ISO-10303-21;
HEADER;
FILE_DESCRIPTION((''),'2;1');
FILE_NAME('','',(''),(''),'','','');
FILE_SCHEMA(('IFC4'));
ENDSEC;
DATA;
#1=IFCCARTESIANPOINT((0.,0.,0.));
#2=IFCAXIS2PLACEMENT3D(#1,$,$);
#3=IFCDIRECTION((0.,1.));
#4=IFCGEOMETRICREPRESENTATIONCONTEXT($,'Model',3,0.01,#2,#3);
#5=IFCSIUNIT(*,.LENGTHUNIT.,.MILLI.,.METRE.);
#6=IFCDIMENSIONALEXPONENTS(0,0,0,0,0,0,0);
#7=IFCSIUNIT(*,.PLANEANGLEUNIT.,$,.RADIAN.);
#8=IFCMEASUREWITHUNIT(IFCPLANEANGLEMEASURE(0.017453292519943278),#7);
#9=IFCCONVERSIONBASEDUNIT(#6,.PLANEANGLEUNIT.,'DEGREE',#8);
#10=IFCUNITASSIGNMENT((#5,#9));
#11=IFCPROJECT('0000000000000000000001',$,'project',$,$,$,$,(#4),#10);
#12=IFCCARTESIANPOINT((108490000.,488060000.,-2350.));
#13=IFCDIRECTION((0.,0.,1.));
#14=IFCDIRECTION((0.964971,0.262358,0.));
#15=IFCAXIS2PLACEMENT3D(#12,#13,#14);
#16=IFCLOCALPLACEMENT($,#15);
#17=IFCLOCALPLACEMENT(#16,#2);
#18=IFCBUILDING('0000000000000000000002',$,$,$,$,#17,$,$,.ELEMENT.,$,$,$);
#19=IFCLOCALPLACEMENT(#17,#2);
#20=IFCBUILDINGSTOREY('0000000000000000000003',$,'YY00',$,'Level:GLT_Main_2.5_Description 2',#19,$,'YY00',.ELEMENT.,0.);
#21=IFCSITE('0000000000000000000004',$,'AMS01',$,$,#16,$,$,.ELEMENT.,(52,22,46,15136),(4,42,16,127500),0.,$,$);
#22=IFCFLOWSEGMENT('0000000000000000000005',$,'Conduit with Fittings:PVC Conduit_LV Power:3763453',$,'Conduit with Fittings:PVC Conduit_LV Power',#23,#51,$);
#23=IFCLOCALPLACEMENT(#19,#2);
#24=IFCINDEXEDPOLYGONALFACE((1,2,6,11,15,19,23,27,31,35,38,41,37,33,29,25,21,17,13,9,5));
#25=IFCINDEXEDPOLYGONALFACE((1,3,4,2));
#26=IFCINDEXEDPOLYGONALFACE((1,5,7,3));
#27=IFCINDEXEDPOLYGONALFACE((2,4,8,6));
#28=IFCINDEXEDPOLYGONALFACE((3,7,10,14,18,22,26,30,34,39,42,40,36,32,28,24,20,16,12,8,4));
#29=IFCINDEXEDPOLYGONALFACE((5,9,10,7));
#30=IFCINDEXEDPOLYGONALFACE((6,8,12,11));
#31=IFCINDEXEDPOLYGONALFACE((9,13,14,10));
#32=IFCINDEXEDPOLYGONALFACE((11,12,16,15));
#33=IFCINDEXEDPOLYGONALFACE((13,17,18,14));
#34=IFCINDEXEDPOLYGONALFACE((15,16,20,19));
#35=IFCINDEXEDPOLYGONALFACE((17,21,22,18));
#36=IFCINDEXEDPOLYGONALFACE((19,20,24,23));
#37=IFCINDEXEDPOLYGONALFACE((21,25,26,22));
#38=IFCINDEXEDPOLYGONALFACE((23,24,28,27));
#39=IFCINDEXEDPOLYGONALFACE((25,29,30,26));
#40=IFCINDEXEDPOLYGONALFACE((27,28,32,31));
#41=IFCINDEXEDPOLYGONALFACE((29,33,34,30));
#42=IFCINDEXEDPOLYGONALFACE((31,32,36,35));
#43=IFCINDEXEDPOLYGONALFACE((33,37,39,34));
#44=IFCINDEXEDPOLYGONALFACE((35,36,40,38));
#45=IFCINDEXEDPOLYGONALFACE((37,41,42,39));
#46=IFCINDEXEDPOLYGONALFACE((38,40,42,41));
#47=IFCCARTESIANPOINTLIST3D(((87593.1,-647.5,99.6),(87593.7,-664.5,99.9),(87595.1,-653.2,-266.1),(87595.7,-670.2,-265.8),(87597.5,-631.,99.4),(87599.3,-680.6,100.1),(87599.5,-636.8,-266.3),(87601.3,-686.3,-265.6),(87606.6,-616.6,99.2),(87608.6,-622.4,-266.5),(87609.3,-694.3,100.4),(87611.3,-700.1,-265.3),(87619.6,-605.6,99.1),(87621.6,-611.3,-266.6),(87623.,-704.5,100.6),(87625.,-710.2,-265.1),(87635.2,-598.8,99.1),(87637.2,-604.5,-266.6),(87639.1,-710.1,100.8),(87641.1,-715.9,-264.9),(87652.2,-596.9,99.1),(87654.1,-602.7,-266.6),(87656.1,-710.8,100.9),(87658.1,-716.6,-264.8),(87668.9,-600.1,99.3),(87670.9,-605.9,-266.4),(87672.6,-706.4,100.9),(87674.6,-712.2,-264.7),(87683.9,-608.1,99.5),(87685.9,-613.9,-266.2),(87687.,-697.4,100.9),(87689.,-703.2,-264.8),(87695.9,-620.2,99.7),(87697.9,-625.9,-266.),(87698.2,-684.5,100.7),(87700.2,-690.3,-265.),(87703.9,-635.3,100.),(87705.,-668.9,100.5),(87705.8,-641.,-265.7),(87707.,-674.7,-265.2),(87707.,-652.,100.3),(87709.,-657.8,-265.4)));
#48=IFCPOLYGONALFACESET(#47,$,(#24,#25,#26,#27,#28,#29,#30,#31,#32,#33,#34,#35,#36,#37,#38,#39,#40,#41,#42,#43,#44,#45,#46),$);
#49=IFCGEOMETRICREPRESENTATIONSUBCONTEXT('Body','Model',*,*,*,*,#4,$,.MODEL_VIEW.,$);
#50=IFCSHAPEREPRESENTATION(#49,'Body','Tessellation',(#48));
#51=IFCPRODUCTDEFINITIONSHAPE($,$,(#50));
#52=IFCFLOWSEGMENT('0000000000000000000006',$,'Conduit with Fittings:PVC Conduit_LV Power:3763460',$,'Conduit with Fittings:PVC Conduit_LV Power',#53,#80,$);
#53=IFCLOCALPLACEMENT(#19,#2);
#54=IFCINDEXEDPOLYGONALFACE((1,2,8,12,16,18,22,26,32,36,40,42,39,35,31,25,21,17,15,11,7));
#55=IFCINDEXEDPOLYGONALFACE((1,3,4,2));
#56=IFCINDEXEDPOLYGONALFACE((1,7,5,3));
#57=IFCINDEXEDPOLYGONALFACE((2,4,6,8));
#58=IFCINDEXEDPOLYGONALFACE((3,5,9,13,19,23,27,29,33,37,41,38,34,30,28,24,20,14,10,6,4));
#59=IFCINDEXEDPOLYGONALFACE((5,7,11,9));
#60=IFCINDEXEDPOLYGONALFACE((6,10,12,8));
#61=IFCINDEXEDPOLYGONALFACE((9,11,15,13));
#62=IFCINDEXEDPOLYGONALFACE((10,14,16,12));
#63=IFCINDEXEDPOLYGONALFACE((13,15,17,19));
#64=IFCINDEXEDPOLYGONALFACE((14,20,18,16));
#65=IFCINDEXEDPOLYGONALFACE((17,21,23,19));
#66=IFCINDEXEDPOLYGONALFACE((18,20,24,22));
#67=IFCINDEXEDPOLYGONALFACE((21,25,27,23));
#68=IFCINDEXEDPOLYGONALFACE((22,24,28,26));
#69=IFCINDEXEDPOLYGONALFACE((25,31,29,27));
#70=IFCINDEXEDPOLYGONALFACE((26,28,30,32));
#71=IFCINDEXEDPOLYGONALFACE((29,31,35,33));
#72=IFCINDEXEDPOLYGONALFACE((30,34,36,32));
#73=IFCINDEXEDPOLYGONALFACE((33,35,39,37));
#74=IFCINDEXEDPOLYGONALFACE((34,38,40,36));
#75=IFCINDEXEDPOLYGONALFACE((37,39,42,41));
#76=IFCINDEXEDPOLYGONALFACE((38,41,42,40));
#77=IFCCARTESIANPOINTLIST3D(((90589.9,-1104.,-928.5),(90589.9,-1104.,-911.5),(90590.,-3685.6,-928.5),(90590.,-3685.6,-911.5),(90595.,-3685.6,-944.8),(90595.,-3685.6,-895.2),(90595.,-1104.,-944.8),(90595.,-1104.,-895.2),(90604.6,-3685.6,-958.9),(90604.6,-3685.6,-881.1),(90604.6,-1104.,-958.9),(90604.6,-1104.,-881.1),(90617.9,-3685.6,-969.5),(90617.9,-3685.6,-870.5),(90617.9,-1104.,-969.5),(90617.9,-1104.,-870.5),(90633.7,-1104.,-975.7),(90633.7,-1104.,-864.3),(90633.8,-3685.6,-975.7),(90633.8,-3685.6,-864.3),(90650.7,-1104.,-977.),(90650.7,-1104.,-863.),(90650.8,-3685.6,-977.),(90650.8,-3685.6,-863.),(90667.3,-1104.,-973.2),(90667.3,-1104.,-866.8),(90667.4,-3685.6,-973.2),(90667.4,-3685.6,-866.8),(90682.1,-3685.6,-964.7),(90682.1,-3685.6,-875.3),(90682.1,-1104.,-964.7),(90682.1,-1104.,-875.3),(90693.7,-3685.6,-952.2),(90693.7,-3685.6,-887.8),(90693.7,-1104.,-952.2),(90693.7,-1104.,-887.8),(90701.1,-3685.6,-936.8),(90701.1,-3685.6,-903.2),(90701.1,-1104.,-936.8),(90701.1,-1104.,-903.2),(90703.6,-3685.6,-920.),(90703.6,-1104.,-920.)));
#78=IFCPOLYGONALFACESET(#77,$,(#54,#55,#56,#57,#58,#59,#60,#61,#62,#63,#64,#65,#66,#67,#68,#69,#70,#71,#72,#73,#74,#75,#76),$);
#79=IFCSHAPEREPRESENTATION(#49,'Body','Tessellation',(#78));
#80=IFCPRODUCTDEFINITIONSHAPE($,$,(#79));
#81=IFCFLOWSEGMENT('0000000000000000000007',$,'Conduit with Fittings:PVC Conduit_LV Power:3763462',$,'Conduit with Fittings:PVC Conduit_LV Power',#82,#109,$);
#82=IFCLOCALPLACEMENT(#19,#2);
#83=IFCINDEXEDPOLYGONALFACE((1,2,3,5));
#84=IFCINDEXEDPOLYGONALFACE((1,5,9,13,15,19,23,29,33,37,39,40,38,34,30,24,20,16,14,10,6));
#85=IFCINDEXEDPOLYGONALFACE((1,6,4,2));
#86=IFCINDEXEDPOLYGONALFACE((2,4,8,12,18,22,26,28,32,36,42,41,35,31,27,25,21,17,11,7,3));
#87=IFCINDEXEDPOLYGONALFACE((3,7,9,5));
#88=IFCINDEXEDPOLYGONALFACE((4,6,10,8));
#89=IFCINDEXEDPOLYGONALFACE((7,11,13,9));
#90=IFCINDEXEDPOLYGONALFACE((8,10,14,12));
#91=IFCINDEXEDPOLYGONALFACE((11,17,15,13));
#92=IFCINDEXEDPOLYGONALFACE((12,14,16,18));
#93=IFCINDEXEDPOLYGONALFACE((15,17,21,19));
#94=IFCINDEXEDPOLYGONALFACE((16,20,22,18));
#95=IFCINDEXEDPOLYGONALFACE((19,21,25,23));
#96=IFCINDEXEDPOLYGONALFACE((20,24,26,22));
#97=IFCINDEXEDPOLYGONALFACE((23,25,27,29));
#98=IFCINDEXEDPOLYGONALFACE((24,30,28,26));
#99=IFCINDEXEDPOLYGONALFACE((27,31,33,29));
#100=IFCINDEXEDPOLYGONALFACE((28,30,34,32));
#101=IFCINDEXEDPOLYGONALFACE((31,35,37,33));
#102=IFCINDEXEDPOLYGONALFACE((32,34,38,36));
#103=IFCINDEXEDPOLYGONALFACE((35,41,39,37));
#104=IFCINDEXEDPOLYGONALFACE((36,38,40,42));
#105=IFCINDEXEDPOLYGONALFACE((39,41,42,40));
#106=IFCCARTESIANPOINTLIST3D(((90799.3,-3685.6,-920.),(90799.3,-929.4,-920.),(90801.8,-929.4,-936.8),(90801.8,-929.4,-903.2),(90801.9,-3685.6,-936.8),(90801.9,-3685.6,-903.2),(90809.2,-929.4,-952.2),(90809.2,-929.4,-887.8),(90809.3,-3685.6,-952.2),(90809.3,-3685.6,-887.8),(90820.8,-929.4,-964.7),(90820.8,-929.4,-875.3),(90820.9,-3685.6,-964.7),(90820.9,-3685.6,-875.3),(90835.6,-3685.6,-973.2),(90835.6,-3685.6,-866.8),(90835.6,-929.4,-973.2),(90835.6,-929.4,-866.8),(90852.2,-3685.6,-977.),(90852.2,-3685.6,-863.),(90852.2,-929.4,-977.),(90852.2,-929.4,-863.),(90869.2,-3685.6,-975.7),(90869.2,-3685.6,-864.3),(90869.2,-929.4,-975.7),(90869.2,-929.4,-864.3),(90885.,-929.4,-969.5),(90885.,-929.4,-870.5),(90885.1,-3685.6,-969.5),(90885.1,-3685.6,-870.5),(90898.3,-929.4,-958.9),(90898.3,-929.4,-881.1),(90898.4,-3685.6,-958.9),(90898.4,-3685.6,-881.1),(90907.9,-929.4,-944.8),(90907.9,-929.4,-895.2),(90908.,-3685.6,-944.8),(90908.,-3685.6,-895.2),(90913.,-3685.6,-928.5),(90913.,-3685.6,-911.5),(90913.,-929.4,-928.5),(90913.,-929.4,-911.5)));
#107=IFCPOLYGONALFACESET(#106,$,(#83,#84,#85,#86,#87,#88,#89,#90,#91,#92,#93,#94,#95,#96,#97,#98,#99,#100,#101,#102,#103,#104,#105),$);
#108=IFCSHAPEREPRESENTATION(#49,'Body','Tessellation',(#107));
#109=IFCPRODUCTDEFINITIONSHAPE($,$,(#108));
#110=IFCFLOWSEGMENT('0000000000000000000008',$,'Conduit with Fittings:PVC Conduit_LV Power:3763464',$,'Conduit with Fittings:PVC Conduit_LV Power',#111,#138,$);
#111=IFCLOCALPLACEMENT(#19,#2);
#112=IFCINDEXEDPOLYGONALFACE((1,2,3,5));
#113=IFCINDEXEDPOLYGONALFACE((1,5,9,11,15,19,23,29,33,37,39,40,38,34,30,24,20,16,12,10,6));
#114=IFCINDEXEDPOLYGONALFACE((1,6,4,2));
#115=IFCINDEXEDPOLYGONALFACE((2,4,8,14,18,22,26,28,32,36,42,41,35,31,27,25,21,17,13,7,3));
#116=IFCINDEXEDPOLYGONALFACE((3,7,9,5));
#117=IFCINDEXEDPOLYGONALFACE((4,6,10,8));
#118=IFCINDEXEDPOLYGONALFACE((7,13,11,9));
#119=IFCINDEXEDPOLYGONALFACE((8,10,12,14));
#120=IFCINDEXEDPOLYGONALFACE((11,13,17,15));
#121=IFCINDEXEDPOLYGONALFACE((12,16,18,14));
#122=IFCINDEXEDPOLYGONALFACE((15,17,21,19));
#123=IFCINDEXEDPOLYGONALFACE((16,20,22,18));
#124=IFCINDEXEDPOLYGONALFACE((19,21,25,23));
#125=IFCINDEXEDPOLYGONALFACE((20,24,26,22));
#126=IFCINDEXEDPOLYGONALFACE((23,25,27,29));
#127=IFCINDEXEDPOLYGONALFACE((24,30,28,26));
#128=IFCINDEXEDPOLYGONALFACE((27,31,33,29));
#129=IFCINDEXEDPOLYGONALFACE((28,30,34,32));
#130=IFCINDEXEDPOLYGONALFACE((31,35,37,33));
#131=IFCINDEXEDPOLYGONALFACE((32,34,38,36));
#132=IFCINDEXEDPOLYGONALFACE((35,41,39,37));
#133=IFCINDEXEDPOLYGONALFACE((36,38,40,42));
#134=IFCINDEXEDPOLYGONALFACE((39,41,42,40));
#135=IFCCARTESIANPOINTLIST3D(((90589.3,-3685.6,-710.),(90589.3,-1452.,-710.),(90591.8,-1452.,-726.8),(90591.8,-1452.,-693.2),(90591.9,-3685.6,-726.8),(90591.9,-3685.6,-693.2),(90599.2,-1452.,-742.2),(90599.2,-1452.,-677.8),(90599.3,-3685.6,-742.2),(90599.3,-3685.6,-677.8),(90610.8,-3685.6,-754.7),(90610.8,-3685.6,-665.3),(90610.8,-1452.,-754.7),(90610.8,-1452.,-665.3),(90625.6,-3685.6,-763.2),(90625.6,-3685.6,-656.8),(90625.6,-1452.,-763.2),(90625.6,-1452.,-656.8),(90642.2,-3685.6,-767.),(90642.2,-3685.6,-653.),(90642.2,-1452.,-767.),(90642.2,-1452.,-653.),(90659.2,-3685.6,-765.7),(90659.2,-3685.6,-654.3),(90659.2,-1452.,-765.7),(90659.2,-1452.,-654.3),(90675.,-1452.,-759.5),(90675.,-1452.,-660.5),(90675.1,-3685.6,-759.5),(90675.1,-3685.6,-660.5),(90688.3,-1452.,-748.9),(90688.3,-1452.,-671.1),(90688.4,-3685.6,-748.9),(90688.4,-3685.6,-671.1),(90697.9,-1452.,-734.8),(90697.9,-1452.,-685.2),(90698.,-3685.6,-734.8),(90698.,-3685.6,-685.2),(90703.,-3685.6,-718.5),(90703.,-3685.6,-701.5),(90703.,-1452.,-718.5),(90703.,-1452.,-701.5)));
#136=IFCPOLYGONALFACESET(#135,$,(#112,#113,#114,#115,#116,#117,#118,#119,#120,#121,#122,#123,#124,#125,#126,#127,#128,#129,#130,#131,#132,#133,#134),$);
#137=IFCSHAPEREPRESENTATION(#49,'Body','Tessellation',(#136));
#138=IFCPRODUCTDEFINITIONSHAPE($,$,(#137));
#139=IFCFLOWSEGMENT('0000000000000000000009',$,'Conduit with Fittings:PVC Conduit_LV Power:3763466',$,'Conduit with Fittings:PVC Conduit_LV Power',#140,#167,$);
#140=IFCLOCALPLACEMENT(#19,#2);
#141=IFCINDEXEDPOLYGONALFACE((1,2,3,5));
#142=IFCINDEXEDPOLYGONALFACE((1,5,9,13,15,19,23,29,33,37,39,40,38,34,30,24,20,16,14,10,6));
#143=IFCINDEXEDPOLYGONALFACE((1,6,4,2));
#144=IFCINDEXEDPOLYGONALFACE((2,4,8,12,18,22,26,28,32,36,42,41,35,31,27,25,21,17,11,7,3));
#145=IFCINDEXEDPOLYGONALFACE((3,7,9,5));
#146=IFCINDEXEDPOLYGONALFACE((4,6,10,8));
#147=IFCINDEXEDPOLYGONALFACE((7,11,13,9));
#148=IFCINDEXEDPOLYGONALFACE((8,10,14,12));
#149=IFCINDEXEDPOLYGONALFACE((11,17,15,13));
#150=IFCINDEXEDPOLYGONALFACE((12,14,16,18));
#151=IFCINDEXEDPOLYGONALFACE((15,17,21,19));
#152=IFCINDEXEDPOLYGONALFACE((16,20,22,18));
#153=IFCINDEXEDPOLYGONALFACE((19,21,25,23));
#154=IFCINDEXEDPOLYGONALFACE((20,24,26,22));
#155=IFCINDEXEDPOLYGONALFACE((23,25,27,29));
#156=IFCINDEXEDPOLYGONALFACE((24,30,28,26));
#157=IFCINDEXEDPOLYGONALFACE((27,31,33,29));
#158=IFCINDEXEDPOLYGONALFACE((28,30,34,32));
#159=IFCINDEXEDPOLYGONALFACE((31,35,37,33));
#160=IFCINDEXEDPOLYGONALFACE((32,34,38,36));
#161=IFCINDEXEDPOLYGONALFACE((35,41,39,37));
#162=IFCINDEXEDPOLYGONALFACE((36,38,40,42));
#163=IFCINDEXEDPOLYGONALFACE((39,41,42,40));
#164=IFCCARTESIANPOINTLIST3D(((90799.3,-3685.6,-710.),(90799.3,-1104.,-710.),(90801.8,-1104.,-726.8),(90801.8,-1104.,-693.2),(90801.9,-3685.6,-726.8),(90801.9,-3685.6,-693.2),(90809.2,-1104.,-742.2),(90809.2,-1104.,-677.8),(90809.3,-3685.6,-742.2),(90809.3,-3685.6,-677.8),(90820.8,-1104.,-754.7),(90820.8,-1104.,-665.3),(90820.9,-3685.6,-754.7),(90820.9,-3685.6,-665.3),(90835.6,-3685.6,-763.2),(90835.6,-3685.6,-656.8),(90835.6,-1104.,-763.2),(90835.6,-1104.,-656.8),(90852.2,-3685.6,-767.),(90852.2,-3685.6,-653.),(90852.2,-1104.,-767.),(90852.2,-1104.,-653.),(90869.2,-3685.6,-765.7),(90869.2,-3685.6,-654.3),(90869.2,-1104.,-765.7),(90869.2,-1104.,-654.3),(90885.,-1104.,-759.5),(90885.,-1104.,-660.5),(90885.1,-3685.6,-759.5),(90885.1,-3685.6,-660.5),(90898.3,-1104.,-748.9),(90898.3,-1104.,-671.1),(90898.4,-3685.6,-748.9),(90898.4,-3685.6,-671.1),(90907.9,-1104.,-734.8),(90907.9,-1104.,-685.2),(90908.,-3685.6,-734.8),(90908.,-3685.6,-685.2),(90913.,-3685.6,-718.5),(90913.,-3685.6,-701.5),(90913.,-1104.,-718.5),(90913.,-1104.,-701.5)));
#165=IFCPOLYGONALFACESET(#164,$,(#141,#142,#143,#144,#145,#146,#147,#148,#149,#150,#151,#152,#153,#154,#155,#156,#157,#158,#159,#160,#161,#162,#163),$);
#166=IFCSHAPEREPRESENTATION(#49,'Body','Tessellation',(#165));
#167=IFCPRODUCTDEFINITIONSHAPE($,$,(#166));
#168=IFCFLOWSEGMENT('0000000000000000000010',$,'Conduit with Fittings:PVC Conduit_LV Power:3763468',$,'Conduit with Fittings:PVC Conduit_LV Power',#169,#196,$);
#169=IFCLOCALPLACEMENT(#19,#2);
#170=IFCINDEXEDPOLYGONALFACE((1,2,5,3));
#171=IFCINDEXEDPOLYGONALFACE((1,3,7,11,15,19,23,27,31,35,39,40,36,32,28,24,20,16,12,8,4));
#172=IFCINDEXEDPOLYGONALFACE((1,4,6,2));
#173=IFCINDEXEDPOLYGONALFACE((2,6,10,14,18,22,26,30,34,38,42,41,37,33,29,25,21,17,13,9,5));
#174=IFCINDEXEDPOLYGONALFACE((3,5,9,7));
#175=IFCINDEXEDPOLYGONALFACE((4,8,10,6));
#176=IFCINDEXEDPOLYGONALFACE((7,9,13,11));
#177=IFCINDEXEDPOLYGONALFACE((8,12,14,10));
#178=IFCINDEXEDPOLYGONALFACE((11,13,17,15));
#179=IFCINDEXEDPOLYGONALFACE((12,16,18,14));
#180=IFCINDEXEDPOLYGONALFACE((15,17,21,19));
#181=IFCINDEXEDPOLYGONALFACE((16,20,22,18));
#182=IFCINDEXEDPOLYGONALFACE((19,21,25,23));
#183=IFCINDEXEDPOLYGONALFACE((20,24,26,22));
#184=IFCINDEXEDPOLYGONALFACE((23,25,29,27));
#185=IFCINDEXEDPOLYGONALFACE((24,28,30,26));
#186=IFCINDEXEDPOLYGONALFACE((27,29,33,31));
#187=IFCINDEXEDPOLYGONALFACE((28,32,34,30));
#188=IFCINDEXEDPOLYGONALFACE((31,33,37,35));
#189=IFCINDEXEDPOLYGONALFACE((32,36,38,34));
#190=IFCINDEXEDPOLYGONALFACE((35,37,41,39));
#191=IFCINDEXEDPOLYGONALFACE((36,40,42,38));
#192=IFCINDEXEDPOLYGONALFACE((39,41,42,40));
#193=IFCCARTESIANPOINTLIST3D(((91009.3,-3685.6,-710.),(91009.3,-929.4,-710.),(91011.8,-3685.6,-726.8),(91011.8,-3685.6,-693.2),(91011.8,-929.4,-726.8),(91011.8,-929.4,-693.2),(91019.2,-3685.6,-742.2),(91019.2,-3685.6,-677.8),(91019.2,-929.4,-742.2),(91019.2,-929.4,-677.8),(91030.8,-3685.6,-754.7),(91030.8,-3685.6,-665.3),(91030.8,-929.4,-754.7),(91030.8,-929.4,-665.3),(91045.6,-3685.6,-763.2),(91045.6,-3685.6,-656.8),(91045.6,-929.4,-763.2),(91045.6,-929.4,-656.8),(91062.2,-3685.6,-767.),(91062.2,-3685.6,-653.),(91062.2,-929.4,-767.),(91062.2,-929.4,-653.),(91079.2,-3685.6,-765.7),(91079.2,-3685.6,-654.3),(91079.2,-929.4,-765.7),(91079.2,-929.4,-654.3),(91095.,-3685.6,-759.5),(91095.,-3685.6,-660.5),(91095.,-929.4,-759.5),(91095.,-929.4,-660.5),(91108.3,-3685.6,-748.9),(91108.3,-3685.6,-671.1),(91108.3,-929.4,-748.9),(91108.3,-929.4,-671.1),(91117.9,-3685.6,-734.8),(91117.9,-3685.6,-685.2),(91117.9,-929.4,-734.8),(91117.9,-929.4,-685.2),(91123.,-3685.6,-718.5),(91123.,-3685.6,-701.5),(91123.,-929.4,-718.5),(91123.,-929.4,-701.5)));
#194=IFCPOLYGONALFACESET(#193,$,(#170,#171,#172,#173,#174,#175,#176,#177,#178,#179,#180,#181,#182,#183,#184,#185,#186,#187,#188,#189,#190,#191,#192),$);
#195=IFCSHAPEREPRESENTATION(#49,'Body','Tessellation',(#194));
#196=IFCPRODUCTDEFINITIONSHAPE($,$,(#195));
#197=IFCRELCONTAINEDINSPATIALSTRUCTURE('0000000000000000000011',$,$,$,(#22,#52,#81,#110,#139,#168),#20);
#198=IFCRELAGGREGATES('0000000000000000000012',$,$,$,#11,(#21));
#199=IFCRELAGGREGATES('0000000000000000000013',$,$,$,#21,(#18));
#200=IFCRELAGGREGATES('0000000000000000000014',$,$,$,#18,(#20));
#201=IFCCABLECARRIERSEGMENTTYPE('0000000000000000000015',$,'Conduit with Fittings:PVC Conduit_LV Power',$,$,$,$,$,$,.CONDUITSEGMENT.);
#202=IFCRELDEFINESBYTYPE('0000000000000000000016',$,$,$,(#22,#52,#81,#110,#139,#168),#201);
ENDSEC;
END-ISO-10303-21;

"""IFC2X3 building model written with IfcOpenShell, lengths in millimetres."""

from ifc_helpers import new_model, entity, si_unit, converted_unit, direction, frame, frame_2d, origin, origin_2d_with_axis, place, context, subcontext, project, spatial, circle, extrude, type_object, element, save


model = new_model("IFC2X3")

# Units and contexts
model_context = context("Model", 3, precision=0.01, world=origin(), true_north=direction((0.0, 1.0)))
body_context = subcontext(model_context, "Body", "Model", "MODEL_VIEW")
ifc_project = project(units=[si_unit("LENGTHUNIT", "METRE", prefix="MILLI"), converted_unit("PLANEANGLEUNIT", "DEGREE", entity("IfcPlaneAngleMeasure", 0.017453292519943278), si_unit("PLANEANGLEUNIT", "RADIAN"), dimensions=[0, 0, 0, 0, 0, 0, 0])], contexts=[model_context])

# Site, building, storey
site_placement = place(None, frame((108490000.0, 488060000.0, -2350.0), z_axis=(0.0, 0.0, 1.0), x_axis=(0.964971, 0.262358, 0.0)))
site = spatial("IfcSite", under=ifc_project, at=site_placement, Name="AMS01", CompositionType="ELEMENT", RefLatitude=(52, 22, 46, 15136), RefLongitude=(4, 42, 16, 127500), RefElevation=0.0)
building_placement = place(site_placement, origin())
building = spatial("IfcBuilding", under=site, at=building_placement, CompositionType="ELEMENT")
storey_placement = place(building_placement, origin())
storey = spatial("IfcBuildingStorey", under=building, at=storey_placement, Name="YY00", ObjectType="Level:GLT_Main_2.5_Description 2", LongName="YY00", CompositionType="ELEMENT", Elevation=0.0)

# Flow segments
cable_carrier_segment_type = type_object("IfcCableCarrierSegmentType", Name="Conduit with Fittings:PVC Conduit_LV Power", PredefinedType="CONDUITSEGMENT")
flow_segment_1_placement = place(storey_placement, origin())
element("IfcFlowSegment", 1, at=flow_segment_1_placement, inside=storey, type_object=cable_carrier_segment_type, Name="Conduit with Fittings:PVC Conduit_LV Power:3763453", ObjectType="Conduit with Fittings:PVC Conduit_LV Power", context=body_context, shape_type="SweptSolid", body=[
    extrude(circle(Radius=57.2, at=frame_2d((0.0, 0.0), x_axis=(1.0, 0.0))), frame((87649.9, -654.0, 100.0), z_axis=(0.005445, -0.015691, -0.999862), x_axis=(0.94474, 0.32782, 0.0)), (0.0, 0.0, 1.0), 365.7),
])
flow_segment_2_placement = place(storey_placement, origin())
element("IfcFlowSegment", 2, at=flow_segment_2_placement, inside=storey, type_object=cable_carrier_segment_type, Name="Conduit with Fittings:PVC Conduit_LV Power:3763460", ObjectType="Conduit with Fittings:PVC Conduit_LV Power", context=body_context, shape_type="SweptSolid", body=[
    extrude(circle(Radius=57.2, at=origin_2d_with_axis()), frame((90646.5, -3685.6, -920.0), z_axis=(-0.000011, 1.0, 0.0), x_axis=(1.0, 0.000011, 0.0)), (0.0, 0.0, 1.0), 2581.6),
])
flow_segment_3_placement = place(storey_placement, origin())
element("IfcFlowSegment", 3, at=flow_segment_3_placement, inside=storey, type_object=cable_carrier_segment_type, Name="Conduit with Fittings:PVC Conduit_LV Power:3763462", ObjectType="Conduit with Fittings:PVC Conduit_LV Power", context=body_context, shape_type="SweptSolid", body=[
    extrude(circle(Radius=57.2, at=frame_2d((0.0, 0.0), x_axis=(1.0, 0.0))), frame((90856.5, -3685.6, -920.0), z_axis=(-0.000012, 1.0, 0.0), x_axis=(-1.0, -0.000012, 0.0)), (0.0, 0.0, 1.0), 2756.2),
])
flow_segment_4_placement = place(storey_placement, origin())
element("IfcFlowSegment", 4, at=flow_segment_4_placement, inside=storey, type_object=cable_carrier_segment_type, Name="Conduit with Fittings:PVC Conduit_LV Power:3763464", ObjectType="Conduit with Fittings:PVC Conduit_LV Power", context=body_context, shape_type="SweptSolid", body=[
    extrude(circle(Radius=57.2, at=origin_2d_with_axis()), frame((90646.5, -1452.0, -710.0), z_axis=(0.000012, -1.0, 0.0), x_axis=(-1.0, -0.000012, 0.0)), (0.0, 0.0, 1.0), 2233.6),
])
flow_segment_5_placement = place(storey_placement, origin())
element("IfcFlowSegment", 5, at=flow_segment_5_placement, inside=storey, type_object=cable_carrier_segment_type, Name="Conduit with Fittings:PVC Conduit_LV Power:3763466", ObjectType="Conduit with Fittings:PVC Conduit_LV Power", context=body_context, shape_type="SweptSolid", body=[
    extrude(circle(Radius=57.2, at=origin_2d_with_axis()), frame((90856.5, -1104.0, -710.0), z_axis=(0.000013, -1.0, 0.0), x_axis=(-1.0, -0.000013, 0.0)), (0.0, 0.0, 1.0), 2581.6),
])
flow_segment_6_placement = place(storey_placement, origin())
element("IfcFlowSegment", 6, at=flow_segment_6_placement, inside=storey, type_object=cable_carrier_segment_type, Name="Conduit with Fittings:PVC Conduit_LV Power:3763468", ObjectType="Conduit with Fittings:PVC Conduit_LV Power", context=body_context, shape_type="SweptSolid", body=[
    extrude(circle(Radius=57.2, at=frame_2d((0.0, 0.0), x_axis=(1.0, 0.0))), frame((91066.4, -3685.6, -710.0), z_axis=(0.000002, 1.0, 0.0), x_axis=(-1.0, 0.000002, 0.0)), (0.0, 0.0, 1.0), 2756.2),
])

save(model, "model.ifc")
